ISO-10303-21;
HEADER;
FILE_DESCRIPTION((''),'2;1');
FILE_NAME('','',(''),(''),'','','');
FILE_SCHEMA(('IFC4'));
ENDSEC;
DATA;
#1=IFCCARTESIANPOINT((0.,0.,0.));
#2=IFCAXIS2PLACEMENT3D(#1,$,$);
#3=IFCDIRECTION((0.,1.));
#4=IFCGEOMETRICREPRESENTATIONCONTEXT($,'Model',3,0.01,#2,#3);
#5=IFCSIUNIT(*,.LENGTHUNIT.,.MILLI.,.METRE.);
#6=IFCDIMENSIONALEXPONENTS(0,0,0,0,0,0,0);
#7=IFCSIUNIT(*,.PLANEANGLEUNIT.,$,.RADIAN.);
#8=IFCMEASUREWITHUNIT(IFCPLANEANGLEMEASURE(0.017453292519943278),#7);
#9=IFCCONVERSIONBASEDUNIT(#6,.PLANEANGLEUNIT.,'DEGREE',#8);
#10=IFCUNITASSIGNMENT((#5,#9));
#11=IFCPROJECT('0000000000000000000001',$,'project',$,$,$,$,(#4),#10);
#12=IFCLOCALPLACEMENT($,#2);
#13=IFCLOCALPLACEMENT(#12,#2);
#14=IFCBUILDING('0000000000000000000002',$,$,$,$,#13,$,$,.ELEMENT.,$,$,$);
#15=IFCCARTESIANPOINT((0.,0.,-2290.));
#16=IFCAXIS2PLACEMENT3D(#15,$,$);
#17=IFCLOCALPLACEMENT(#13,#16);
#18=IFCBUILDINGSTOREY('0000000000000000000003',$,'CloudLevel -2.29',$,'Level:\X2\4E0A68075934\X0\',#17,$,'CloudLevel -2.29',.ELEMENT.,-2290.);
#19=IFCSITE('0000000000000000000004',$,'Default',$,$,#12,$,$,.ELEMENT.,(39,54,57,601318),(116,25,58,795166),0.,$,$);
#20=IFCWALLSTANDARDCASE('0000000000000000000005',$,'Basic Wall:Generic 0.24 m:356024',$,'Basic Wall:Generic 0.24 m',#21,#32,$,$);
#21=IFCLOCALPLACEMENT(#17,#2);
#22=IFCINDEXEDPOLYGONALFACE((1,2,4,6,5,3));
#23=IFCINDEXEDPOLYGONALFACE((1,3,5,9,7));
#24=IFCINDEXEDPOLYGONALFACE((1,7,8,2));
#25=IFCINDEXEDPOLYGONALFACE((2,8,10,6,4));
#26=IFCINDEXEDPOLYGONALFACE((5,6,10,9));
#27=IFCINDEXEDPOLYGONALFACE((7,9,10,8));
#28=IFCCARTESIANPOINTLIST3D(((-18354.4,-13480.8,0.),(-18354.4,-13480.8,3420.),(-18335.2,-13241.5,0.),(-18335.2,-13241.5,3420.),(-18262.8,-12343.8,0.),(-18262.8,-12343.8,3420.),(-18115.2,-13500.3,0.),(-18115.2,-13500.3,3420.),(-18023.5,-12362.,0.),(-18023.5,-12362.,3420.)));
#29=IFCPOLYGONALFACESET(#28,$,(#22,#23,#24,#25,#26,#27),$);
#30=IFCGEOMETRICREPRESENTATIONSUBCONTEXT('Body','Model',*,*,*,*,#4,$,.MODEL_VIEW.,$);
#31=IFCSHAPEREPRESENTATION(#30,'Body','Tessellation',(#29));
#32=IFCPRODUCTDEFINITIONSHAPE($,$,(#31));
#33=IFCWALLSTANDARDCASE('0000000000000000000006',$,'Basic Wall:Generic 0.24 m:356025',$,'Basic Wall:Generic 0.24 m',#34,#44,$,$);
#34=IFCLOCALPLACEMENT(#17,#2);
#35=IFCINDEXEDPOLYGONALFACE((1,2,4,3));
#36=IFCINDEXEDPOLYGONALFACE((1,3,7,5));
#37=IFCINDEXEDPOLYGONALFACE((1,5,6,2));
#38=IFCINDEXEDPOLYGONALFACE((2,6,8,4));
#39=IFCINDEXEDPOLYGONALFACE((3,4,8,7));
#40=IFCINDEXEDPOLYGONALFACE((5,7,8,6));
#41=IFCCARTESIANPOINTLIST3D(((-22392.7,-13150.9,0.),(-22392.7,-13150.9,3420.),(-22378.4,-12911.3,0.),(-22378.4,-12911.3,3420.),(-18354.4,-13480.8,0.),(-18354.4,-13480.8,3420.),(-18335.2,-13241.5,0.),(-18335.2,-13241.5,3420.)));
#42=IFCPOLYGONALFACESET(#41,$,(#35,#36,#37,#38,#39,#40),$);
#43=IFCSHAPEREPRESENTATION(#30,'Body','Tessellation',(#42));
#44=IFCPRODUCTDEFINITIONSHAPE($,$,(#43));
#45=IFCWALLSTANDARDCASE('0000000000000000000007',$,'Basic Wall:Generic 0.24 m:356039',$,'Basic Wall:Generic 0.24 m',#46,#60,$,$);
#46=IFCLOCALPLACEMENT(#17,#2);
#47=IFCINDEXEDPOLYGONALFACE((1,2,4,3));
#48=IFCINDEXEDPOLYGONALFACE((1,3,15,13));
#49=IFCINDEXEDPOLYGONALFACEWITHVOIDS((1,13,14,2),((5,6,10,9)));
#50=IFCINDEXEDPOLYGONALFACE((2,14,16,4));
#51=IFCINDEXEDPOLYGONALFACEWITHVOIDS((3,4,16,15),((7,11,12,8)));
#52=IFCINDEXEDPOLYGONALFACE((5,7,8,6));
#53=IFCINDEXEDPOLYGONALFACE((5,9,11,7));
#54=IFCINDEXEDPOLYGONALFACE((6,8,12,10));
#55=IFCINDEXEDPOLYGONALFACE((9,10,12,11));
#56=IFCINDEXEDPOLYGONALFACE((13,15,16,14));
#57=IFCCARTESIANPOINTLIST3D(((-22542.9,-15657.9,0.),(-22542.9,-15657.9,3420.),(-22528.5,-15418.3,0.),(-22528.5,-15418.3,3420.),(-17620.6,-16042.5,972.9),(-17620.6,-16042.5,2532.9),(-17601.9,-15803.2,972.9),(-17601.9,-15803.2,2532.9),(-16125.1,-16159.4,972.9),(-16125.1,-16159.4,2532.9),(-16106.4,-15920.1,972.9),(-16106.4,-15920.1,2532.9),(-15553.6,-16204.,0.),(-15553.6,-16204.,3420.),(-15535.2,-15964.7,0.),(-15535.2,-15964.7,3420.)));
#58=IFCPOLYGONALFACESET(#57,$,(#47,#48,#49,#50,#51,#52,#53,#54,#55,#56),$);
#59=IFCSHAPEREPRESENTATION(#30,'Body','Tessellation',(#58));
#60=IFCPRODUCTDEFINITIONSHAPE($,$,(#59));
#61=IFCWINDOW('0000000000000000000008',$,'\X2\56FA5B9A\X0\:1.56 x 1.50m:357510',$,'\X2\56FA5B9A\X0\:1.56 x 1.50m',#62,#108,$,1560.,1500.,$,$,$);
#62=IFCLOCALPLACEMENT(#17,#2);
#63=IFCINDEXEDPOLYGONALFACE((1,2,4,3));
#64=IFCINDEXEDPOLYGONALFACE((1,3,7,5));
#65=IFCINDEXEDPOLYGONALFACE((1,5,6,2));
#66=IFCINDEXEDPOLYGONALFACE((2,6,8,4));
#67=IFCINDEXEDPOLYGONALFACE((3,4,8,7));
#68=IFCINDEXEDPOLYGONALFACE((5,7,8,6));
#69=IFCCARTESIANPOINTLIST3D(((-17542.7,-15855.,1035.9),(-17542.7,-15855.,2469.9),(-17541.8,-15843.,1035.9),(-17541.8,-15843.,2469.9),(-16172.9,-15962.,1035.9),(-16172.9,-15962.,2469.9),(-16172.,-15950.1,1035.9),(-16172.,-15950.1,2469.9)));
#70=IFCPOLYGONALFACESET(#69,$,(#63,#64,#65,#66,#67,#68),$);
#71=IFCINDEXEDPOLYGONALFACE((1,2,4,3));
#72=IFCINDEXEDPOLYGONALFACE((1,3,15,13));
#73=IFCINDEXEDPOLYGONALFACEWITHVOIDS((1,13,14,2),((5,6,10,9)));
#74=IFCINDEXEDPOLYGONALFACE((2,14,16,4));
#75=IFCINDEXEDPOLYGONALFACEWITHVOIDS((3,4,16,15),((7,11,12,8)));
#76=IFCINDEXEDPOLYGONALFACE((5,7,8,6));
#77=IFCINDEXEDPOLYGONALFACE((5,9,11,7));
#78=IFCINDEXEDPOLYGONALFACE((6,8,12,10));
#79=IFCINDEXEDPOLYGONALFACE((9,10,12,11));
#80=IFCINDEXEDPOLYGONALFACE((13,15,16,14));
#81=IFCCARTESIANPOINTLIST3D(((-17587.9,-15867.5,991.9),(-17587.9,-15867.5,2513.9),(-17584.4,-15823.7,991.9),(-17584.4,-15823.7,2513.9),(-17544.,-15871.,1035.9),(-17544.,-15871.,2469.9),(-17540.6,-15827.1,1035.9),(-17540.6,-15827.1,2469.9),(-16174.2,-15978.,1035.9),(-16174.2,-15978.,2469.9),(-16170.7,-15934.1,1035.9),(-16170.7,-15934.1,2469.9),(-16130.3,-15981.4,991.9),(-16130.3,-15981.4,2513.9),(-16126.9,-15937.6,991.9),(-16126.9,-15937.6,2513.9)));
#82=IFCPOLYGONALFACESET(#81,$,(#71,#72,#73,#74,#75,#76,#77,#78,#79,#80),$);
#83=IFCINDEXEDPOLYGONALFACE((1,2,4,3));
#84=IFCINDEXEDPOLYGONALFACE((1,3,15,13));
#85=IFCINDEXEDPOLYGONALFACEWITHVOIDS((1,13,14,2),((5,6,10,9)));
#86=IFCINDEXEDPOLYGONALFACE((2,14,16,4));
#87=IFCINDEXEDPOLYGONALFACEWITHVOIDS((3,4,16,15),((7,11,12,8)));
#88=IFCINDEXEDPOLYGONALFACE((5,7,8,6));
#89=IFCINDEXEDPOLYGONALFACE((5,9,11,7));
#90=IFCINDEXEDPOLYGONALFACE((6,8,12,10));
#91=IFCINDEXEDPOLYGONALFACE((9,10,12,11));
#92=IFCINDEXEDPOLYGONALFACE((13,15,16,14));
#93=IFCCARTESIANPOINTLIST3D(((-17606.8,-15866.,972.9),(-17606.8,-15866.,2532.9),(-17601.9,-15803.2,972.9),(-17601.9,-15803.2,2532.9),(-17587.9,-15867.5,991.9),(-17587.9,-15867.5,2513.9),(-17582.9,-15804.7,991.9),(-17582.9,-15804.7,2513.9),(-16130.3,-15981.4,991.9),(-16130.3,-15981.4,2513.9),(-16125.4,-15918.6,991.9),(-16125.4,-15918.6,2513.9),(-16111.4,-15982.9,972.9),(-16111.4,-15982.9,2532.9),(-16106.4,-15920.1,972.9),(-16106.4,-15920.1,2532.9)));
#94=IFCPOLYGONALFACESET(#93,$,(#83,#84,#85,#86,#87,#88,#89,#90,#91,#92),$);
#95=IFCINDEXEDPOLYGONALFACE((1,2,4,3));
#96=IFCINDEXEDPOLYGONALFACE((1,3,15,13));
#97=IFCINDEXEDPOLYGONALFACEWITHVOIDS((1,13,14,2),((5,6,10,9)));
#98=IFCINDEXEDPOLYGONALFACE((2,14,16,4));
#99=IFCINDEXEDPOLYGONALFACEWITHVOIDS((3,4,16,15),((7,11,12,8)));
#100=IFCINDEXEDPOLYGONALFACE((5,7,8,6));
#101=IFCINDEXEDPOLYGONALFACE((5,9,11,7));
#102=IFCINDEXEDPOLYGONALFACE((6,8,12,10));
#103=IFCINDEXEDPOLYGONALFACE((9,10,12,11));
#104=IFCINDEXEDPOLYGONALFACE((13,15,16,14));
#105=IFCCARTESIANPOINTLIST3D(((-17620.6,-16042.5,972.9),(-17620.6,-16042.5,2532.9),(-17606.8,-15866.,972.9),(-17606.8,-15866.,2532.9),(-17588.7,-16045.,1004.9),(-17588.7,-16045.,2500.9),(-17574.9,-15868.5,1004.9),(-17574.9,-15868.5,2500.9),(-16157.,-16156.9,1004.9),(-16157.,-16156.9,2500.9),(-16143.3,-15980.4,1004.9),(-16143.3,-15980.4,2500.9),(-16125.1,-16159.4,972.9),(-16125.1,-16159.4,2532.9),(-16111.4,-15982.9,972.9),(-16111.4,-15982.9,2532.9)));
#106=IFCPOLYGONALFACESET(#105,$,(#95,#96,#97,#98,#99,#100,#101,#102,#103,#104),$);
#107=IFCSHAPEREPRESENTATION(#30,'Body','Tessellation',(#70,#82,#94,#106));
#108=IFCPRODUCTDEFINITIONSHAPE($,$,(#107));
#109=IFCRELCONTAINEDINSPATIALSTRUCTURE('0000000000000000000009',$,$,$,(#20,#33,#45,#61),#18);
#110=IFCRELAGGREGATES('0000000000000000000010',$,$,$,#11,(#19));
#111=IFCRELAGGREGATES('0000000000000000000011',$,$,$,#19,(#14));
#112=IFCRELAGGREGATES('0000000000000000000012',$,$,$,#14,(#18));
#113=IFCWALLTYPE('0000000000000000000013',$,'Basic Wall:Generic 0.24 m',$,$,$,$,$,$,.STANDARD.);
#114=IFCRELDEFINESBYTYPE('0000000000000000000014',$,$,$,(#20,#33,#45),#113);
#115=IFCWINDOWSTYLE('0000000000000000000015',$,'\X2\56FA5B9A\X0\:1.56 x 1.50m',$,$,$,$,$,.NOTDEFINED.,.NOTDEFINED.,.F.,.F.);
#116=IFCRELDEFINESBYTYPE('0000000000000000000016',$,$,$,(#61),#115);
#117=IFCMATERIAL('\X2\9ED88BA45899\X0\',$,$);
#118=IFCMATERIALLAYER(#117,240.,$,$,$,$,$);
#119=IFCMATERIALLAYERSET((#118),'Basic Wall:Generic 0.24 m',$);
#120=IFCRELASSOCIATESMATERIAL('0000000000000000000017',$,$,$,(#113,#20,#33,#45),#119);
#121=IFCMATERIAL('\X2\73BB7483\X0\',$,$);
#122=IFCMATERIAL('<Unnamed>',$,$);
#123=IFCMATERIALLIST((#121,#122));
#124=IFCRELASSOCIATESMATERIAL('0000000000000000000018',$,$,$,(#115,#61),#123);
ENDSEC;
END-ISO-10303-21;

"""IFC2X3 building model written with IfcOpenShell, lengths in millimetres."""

from ifc_helpers import new_model, entity, si_unit, converted_unit, direction, frame, frame_2d, origin, place, context, subcontext, project, spatial, polyline, rectangle, outline, extrude, source, transform, mapped, material, material_list, layer, layer_set, layer_usage, type_object, type_shapes, element, fill, save


model = new_model("IFC2X3")

# Units and contexts
model_context = context("Model", 3, precision=0.01, world=origin(), true_north=direction((0.0, 1.0)))
body_context = subcontext(model_context, "Body", "Model", "MODEL_VIEW")
ifc_project = project(units=[si_unit("LENGTHUNIT", "METRE", prefix="MILLI"), converted_unit("PLANEANGLEUNIT", "DEGREE", entity("IfcPlaneAngleMeasure", 0.017453292519943278), si_unit("PLANEANGLEUNIT", "RADIAN"), dimensions=[0, 0, 0, 0, 0, 0, 0])], contexts=[model_context])

# Site, building, storey
site_placement = place(None, origin())
site = spatial("IfcSite", under=ifc_project, at=site_placement, Name="Default", CompositionType="ELEMENT", RefLatitude=(39, 54, 57, 601318), RefLongitude=(116, 25, 58, 795166), RefElevation=0.0)
building_placement = place(site_placement, origin())
building = spatial("IfcBuilding", under=site, at=building_placement, CompositionType="ELEMENT")
storey_placement = place(building_placement, frame((0.0, 0.0, -2290.0)))
storey = spatial("IfcBuildingStorey", under=building, at=storey_placement, Name="CloudLevel -2.29", ObjectType="Level:上标头", LongName="CloudLevel -2.29", CompositionType="ELEMENT", Elevation=-2290.0)

# Walls
ifc_material_1 = material(Name="默认墙")
ifc_layer_1 = layer(ifc_material_1, 240.0)
ifc_layer_set_1 = layer_set([ifc_layer_1], Name="Basic Wall:Generic 0.24 m")
ifc_layer_usage_1 = layer_usage(ifc_layer_set_1, "AXIS2", "NEGATIVE", 120.0)
wall_type_1 = type_object("IfcWallType", Name="Basic Wall:Generic 0.24 m", PredefinedType="STANDARD", material=ifc_layer_set_1)
wall_1_placement = place(storey_placement, frame((-18143.1, -12352.3, 0.0), z_axis=(0.0, 0.0, 1.0), x_axis=(-0.080362, -0.996766, 0.0)))
element("IfcWallStandardCase", 1, at=wall_1_placement, inside=storey, type_object=wall_type_1, material=ifc_layer_usage_1, Name="Basic Wall:Generic 0.24 m:356024", ObjectType="Basic Wall:Generic 0.24 m", context=body_context, shape_type="SweptSolid", body=[
    extrude(outline(polyline([(1141.8, -120.0), (1142.0, 120.0), (0.0, 120.0), (1.1, -120.0), (901.8, -120.0), (1141.8, -120.0)])), origin(), (0.0, 0.0, 1.0), 3420.0),
])
wall_2_placement = place(storey_placement, frame((-18344.7, -13361.2, 0.0), z_axis=(0.0, 0.0, 1.0), x_axis=(-0.99668, 0.081414, 0.0)))
element("IfcWallStandardCase", 2, at=wall_2_placement, inside=storey, type_object=wall_type_1, material=ifc_layer_usage_1, Name="Basic Wall:Generic 0.24 m:356025", ObjectType="Basic Wall:Generic 0.24 m", context=body_context, shape_type="SweptSolid", body=[
    extrude(outline(polyline([(4057.0, -120.0), (4051.7, 120.0), (0.0, 120.0), (0.3, -120.0), (4057.0, -120.0)])), origin(), (0.0, 0.0, 1.0), 3420.0),
])

# Wall, opening, window
wall_3_placement = place(storey_placement, frame((-15544.3, -16084.4, 0.0), z_axis=(0.0, 0.0, 1.0), x_axis=(-0.996961, 0.077901, 0.0)))
wall_3 = element("IfcWallStandardCase", 3, at=wall_3_placement, inside=storey, type_object=wall_type_1, material=ifc_layer_usage_1, Name="Basic Wall:Generic 0.24 m:356039", ObjectType="Basic Wall:Generic 0.24 m", context=body_context, shape_type="SweptSolid", body=[
    extrude(outline(polyline([(7014.9, -120.0), (7010.5, 120.0), (0.0, 120.0), (0.3, -120.0), (7014.9, -120.0)])), origin(), (0.0, 0.0, 1.0), 3420.0),
])
opening_1_placement = place(wall_3_placement, frame((2073.3, 120.0, 972.9)))
opening_1 = element("IfcOpeningElement", 4, at=opening_1_placement, cuts=wall_3, ObjectType="Opening", context=body_context, shape_type="SweptSolid", body=[
    extrude(rectangle(XDim=1560.0, YDim=1500.0, at=frame_2d((780.0, 750.0), x_axis=(1.0, 0.0))), frame((0.0, 0.0, 0.0), z_axis=(0.0, -1.0, 0.0), x_axis=(0.0, 0.0, 1.0)), (0.0, 0.0, 1.0), 240.0),
])
ifc_material_2 = material(Name="玻璃")
ifc_material_3 = material(Name="<Unnamed>")
ifc_material_list = material_list([ifc_material_2, ifc_material_3])
window_style_1 = type_object("IfcWindowStyle", Name="固定:1.56 x 1.50m", ConstructionType="NOTDEFINED", OperationType="NOTDEFINED", ParameterTakesPrecedence=False, Sizeable=False, material=ifc_material_list)
shared_shape_1 = source(origin(), body_context, "Body", "SweptSolid", [
    extrude(rectangle(XDim=1374.0, YDim=12.0, at=frame_2d((0.0, 0.0), x_axis=(1.0, 0.0))), frame((750.0, 225.0, 63.0), z_axis=(0.0, 0.0, 1.0), x_axis=(-1.0, 0.0, 0.0)), (0.0, 0.0, 1.0), 1434.0),
    extrude(outline(polyline([(-731.0, -761.0), (731.0, -761.0), (731.0, 761.0), (-731.0, 761.0), (-731.0, -761.0)]), holes=[polyline([(-687.0, -717.0), (-687.0, 717.0), (687.0, 717.0), (687.0, -717.0), (-687.0, -717.0)])]), frame((750.0, 247.0, 780.0), z_axis=(0.0, -1.0, 0.0), x_axis=(-1.0, 0.0, 0.0)), (0.0, 0.0, 1.0), 44.0),
    extrude(outline(polyline([(-750.0, -780.0), (750.0, -780.0), (750.0, 780.0), (-750.0, 780.0), (-750.0, -780.0)]), holes=[polyline([(-731.0, -761.0), (-731.0, 761.0), (731.0, 761.0), (731.0, -761.0), (-731.0, -761.0)])]), frame((750.0, 266.0, 780.0), z_axis=(0.0, -1.0, 0.0), x_axis=(-1.0, 0.0, 0.0)), (0.0, 0.0, 1.0), 63.0),
    extrude(outline(polyline([(-750.0, -780.0), (750.0, -780.0), (750.0, 780.0), (-750.0, 780.0), (-750.0, -780.0)]), holes=[polyline([(-718.0, -748.0), (-718.0, 748.0), (718.0, 748.0), (718.0, -748.0), (-718.0, -748.0)])]), frame((750.0, 203.0, 780.0), z_axis=(0.0, -1.0, 0.0), x_axis=(-1.0, 0.0, 0.0)), (0.0, 0.0, 1.0), 177.0),
])
type_shapes(window_style_1, [shared_shape_1])
window_1_placement = place(opening_1_placement, frame((0.0, 26.0, 0.0), z_axis=(0.0, 0.0, 1.0), x_axis=(-1.0, 0.0, 0.0)))
window_1 = element("IfcWindow", 5, at=window_1_placement, inside=storey, type_object=window_style_1, material=ifc_material_list, Name="固定:1.56 x 1.50m:357510", ObjectType="固定:1.56 x 1.50m", OverallHeight=1560.0, OverallWidth=1500.0, context=body_context, shape_type="MappedRepresentation", body=[
    mapped(shared_shape_1, transform((0.0, 0.0, 0.0), scale=1.0)),
])
fill(opening_1, window_1)

save(model, "model.ifc")
